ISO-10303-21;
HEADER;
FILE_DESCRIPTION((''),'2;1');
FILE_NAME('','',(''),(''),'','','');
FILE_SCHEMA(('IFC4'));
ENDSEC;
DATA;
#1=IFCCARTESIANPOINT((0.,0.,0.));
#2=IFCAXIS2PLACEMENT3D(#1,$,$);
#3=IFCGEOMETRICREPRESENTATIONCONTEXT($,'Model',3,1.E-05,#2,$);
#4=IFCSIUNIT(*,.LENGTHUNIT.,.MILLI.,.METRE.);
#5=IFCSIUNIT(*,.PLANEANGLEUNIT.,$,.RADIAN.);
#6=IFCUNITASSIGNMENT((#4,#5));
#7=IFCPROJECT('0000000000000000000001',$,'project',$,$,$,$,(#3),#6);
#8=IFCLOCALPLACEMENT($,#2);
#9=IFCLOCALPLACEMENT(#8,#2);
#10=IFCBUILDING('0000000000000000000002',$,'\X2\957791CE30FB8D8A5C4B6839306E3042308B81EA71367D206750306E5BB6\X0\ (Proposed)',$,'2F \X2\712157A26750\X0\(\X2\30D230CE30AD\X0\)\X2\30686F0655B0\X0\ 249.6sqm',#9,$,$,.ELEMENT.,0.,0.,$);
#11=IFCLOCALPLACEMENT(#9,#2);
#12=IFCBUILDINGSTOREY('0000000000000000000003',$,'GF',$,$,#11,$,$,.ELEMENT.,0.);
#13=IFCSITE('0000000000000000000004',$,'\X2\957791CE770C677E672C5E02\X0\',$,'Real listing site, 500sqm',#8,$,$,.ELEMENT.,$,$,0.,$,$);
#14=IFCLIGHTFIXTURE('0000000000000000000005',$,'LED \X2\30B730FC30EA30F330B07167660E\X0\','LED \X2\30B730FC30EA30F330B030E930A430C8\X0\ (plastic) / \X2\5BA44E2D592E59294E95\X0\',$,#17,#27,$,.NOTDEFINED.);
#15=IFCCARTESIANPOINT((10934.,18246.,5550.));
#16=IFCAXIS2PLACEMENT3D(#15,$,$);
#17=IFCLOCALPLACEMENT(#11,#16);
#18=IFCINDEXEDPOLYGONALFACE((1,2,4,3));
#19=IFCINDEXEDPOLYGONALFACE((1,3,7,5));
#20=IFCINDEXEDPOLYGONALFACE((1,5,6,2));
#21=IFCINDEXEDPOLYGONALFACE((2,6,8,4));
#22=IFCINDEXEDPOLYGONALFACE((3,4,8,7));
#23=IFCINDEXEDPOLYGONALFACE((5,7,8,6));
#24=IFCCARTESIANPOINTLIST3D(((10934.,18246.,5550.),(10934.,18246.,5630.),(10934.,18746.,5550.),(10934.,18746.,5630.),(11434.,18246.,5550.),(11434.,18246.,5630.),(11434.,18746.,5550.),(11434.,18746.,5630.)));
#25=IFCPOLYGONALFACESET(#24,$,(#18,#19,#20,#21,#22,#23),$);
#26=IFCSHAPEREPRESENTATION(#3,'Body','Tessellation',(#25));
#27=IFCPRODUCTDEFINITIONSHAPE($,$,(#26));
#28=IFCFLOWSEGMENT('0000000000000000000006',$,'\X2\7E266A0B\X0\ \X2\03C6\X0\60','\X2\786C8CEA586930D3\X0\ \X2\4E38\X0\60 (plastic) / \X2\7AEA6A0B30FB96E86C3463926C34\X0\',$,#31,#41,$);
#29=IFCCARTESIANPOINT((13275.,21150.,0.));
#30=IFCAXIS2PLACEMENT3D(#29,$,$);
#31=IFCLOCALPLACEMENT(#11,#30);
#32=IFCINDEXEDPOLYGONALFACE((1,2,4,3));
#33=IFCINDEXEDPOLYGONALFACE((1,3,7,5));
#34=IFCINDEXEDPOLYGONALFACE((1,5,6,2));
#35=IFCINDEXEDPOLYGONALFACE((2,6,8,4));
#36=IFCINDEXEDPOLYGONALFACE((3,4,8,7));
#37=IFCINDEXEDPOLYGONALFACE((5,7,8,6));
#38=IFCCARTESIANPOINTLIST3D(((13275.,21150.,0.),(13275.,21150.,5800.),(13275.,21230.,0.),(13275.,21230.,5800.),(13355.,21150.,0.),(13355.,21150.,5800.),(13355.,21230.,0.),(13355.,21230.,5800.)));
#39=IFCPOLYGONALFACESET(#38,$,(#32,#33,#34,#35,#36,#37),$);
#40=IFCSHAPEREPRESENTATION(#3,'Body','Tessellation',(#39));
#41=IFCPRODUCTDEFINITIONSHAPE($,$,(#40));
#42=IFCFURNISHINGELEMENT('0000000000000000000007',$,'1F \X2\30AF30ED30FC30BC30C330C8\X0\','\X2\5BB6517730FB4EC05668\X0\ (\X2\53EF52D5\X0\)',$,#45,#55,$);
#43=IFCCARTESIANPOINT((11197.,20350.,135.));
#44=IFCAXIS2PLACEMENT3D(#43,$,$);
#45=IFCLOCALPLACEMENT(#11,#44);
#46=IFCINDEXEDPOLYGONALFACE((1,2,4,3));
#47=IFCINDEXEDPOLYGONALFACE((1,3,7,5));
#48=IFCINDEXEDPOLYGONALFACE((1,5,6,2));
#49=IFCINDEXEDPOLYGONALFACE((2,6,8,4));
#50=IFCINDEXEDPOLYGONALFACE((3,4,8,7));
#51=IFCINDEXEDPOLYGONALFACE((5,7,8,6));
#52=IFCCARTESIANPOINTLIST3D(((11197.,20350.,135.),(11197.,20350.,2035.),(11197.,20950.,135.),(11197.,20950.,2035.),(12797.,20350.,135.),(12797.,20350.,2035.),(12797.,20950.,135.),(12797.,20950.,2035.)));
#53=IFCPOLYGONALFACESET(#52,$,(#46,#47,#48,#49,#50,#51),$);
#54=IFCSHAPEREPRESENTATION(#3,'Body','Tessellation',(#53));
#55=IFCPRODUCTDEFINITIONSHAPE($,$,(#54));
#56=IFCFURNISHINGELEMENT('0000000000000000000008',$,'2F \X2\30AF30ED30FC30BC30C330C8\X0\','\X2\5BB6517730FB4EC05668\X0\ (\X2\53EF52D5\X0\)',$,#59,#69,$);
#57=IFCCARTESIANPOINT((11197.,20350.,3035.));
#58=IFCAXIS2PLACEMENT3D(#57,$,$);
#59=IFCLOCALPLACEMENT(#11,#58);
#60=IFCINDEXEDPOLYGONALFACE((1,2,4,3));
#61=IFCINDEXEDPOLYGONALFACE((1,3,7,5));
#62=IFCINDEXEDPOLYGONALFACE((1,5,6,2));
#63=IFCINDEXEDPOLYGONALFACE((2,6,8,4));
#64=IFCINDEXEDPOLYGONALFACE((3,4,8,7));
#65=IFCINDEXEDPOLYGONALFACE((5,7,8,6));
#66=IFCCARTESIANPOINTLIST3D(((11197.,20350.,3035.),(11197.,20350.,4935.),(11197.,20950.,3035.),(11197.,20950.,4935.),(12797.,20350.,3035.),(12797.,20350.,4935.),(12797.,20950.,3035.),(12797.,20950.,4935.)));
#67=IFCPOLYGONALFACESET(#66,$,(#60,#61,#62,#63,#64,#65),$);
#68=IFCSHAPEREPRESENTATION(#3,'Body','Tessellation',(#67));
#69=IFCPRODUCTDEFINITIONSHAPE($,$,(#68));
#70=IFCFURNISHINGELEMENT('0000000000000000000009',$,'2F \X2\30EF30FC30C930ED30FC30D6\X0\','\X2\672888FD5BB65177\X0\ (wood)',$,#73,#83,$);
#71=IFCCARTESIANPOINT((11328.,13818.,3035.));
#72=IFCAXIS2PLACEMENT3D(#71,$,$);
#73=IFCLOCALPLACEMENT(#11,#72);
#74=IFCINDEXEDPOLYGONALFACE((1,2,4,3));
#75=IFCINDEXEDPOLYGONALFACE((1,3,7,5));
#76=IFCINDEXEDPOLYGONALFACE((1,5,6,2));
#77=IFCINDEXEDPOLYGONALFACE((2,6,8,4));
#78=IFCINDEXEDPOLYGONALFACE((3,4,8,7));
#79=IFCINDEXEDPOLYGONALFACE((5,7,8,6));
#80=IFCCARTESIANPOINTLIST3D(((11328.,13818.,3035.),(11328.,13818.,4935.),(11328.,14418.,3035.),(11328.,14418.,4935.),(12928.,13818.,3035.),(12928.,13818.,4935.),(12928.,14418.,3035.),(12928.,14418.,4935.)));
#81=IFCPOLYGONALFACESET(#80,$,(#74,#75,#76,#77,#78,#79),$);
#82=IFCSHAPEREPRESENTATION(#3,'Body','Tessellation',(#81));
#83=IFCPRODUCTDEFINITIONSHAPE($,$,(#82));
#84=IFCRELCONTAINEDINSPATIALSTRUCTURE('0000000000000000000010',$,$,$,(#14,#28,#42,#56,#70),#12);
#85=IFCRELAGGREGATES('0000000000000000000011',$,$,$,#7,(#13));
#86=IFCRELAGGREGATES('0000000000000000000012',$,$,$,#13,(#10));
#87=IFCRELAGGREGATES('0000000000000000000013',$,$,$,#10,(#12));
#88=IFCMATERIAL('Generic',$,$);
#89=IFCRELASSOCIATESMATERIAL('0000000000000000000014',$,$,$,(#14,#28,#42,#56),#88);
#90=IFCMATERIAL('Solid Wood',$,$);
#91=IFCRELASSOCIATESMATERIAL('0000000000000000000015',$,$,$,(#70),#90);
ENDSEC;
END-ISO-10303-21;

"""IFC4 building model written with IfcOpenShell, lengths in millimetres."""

from ifc_helpers import new_model, si_unit, frame, frame_2d, origin, place, context, project, spatial, rectangle, extrude, material, element, save


model = new_model("IFC4")

# Units and contexts
model_context = context("Model", 3, precision=1e-05, world=origin())
ifc_project = project(units=[si_unit("LENGTHUNIT", "METRE", prefix="MILLI"), si_unit("PLANEANGLEUNIT", "RADIAN")], contexts=[model_context])

# Site, building, storey
site_placement = place(None, origin())
site = spatial("IfcSite", under=ifc_project, at=site_placement, Name="長野県松本市", ObjectType="Real listing site, 500sqm", CompositionType="ELEMENT", RefElevation=0.0)
building_placement = place(site_placement, origin())
building = spatial("IfcBuilding", under=site, at=building_placement, Name="長野・越屋根のある自然素材の家 (Proposed)", ObjectType="2F 無垢材(ヒノキ)と漆喰 249.6sqm", CompositionType="ELEMENT", ElevationOfRefHeight=0.0, ElevationOfTerrain=0.0)
storey_placement = place(building_placement, origin())
storey = spatial("IfcBuildingStorey", under=building, at=storey_placement, Name="GF", CompositionType="ELEMENT", Elevation=0.0)

# Shared definitions
ifc_material_1 = material(Name="Solid Wood")

# Shared definitions
ifc_material_2 = material(Name="Generic")

# Light fixture
light_fixture_1_placement = place(storey_placement, frame((10934.0, 18246.0, 5550.0)))
element("IfcLightFixture", 1, at=light_fixture_1_placement, inside=storey, material=ifc_material_2, Name="LED シーリング照明", Description="LED シーリングライト (plastic) / 室中央天井", PredefinedType="NOTDEFINED", context=model_context, shape_type="SweptSolid", body=[
    extrude(rectangle(XDim=500.0, YDim=500.0, at=frame_2d((250.0, 250.0))), frame((10934.0, 18246.0, 5550.0)), (0.0, 0.0, 1.0), 80.0),
])

# Flow segment
flow_segment_placement = place(storey_placement, frame((13275.0, 21150.0, 0.0)))
element("IfcFlowSegment", 2, at=flow_segment_placement, inside=storey, material=ifc_material_2, Name="縦樋 φ60", Description="硬質塩ビ 丸60 (plastic) / 竪樋・雨水排水", context=model_context, shape_type="SweptSolid", body=[
    extrude(rectangle(XDim=80.0, YDim=80.0, at=frame_2d((40.0, 40.0))), frame((13275.0, 21150.0, 0.0)), (0.0, 0.0, 1.0), 5800.0),
])

# Furnishing elements
furnishing_1_placement = place(storey_placement, frame((11197.0, 20350.0, 135.0)))
element("IfcFurnishingElement", 3, at=furnishing_1_placement, inside=storey, material=ifc_material_2, Name="1F クローゼット", Description="家具・什器 (可動)", context=model_context, shape_type="SweptSolid", body=[
    extrude(rectangle(XDim=1600.0, YDim=600.0, at=frame_2d((800.0, 300.0))), frame((11197.0, 20350.0, 135.0)), (0.0, 0.0, 1.0), 1900.0),
])
furnishing_2_placement = place(storey_placement, frame((11197.0, 20350.0, 3035.0)))
element("IfcFurnishingElement", 4, at=furnishing_2_placement, inside=storey, material=ifc_material_2, Name="2F クローゼット", Description="家具・什器 (可動)", context=model_context, shape_type="SweptSolid", body=[
    extrude(rectangle(XDim=1600.0, YDim=600.0, at=frame_2d((800.0, 300.0))), frame((11197.0, 20350.0, 3035.0)), (0.0, 0.0, 1.0), 1900.0),
])
furnishing_3_placement = place(storey_placement, frame((11328.0, 13818.0, 3035.0)))
element("IfcFurnishingElement", 5, at=furnishing_3_placement, inside=storey, material=ifc_material_1, Name="2F ワードローブ", Description="木製家具 (wood)", context=model_context, shape_type="SweptSolid", body=[
    extrude(rectangle(XDim=1600.0, YDim=600.0, at=frame_2d((800.0, 300.0))), frame((11328.0, 13818.0, 3035.0)), (0.0, 0.0, 1.0), 1900.0),
])

save(model, "model.ifc")
